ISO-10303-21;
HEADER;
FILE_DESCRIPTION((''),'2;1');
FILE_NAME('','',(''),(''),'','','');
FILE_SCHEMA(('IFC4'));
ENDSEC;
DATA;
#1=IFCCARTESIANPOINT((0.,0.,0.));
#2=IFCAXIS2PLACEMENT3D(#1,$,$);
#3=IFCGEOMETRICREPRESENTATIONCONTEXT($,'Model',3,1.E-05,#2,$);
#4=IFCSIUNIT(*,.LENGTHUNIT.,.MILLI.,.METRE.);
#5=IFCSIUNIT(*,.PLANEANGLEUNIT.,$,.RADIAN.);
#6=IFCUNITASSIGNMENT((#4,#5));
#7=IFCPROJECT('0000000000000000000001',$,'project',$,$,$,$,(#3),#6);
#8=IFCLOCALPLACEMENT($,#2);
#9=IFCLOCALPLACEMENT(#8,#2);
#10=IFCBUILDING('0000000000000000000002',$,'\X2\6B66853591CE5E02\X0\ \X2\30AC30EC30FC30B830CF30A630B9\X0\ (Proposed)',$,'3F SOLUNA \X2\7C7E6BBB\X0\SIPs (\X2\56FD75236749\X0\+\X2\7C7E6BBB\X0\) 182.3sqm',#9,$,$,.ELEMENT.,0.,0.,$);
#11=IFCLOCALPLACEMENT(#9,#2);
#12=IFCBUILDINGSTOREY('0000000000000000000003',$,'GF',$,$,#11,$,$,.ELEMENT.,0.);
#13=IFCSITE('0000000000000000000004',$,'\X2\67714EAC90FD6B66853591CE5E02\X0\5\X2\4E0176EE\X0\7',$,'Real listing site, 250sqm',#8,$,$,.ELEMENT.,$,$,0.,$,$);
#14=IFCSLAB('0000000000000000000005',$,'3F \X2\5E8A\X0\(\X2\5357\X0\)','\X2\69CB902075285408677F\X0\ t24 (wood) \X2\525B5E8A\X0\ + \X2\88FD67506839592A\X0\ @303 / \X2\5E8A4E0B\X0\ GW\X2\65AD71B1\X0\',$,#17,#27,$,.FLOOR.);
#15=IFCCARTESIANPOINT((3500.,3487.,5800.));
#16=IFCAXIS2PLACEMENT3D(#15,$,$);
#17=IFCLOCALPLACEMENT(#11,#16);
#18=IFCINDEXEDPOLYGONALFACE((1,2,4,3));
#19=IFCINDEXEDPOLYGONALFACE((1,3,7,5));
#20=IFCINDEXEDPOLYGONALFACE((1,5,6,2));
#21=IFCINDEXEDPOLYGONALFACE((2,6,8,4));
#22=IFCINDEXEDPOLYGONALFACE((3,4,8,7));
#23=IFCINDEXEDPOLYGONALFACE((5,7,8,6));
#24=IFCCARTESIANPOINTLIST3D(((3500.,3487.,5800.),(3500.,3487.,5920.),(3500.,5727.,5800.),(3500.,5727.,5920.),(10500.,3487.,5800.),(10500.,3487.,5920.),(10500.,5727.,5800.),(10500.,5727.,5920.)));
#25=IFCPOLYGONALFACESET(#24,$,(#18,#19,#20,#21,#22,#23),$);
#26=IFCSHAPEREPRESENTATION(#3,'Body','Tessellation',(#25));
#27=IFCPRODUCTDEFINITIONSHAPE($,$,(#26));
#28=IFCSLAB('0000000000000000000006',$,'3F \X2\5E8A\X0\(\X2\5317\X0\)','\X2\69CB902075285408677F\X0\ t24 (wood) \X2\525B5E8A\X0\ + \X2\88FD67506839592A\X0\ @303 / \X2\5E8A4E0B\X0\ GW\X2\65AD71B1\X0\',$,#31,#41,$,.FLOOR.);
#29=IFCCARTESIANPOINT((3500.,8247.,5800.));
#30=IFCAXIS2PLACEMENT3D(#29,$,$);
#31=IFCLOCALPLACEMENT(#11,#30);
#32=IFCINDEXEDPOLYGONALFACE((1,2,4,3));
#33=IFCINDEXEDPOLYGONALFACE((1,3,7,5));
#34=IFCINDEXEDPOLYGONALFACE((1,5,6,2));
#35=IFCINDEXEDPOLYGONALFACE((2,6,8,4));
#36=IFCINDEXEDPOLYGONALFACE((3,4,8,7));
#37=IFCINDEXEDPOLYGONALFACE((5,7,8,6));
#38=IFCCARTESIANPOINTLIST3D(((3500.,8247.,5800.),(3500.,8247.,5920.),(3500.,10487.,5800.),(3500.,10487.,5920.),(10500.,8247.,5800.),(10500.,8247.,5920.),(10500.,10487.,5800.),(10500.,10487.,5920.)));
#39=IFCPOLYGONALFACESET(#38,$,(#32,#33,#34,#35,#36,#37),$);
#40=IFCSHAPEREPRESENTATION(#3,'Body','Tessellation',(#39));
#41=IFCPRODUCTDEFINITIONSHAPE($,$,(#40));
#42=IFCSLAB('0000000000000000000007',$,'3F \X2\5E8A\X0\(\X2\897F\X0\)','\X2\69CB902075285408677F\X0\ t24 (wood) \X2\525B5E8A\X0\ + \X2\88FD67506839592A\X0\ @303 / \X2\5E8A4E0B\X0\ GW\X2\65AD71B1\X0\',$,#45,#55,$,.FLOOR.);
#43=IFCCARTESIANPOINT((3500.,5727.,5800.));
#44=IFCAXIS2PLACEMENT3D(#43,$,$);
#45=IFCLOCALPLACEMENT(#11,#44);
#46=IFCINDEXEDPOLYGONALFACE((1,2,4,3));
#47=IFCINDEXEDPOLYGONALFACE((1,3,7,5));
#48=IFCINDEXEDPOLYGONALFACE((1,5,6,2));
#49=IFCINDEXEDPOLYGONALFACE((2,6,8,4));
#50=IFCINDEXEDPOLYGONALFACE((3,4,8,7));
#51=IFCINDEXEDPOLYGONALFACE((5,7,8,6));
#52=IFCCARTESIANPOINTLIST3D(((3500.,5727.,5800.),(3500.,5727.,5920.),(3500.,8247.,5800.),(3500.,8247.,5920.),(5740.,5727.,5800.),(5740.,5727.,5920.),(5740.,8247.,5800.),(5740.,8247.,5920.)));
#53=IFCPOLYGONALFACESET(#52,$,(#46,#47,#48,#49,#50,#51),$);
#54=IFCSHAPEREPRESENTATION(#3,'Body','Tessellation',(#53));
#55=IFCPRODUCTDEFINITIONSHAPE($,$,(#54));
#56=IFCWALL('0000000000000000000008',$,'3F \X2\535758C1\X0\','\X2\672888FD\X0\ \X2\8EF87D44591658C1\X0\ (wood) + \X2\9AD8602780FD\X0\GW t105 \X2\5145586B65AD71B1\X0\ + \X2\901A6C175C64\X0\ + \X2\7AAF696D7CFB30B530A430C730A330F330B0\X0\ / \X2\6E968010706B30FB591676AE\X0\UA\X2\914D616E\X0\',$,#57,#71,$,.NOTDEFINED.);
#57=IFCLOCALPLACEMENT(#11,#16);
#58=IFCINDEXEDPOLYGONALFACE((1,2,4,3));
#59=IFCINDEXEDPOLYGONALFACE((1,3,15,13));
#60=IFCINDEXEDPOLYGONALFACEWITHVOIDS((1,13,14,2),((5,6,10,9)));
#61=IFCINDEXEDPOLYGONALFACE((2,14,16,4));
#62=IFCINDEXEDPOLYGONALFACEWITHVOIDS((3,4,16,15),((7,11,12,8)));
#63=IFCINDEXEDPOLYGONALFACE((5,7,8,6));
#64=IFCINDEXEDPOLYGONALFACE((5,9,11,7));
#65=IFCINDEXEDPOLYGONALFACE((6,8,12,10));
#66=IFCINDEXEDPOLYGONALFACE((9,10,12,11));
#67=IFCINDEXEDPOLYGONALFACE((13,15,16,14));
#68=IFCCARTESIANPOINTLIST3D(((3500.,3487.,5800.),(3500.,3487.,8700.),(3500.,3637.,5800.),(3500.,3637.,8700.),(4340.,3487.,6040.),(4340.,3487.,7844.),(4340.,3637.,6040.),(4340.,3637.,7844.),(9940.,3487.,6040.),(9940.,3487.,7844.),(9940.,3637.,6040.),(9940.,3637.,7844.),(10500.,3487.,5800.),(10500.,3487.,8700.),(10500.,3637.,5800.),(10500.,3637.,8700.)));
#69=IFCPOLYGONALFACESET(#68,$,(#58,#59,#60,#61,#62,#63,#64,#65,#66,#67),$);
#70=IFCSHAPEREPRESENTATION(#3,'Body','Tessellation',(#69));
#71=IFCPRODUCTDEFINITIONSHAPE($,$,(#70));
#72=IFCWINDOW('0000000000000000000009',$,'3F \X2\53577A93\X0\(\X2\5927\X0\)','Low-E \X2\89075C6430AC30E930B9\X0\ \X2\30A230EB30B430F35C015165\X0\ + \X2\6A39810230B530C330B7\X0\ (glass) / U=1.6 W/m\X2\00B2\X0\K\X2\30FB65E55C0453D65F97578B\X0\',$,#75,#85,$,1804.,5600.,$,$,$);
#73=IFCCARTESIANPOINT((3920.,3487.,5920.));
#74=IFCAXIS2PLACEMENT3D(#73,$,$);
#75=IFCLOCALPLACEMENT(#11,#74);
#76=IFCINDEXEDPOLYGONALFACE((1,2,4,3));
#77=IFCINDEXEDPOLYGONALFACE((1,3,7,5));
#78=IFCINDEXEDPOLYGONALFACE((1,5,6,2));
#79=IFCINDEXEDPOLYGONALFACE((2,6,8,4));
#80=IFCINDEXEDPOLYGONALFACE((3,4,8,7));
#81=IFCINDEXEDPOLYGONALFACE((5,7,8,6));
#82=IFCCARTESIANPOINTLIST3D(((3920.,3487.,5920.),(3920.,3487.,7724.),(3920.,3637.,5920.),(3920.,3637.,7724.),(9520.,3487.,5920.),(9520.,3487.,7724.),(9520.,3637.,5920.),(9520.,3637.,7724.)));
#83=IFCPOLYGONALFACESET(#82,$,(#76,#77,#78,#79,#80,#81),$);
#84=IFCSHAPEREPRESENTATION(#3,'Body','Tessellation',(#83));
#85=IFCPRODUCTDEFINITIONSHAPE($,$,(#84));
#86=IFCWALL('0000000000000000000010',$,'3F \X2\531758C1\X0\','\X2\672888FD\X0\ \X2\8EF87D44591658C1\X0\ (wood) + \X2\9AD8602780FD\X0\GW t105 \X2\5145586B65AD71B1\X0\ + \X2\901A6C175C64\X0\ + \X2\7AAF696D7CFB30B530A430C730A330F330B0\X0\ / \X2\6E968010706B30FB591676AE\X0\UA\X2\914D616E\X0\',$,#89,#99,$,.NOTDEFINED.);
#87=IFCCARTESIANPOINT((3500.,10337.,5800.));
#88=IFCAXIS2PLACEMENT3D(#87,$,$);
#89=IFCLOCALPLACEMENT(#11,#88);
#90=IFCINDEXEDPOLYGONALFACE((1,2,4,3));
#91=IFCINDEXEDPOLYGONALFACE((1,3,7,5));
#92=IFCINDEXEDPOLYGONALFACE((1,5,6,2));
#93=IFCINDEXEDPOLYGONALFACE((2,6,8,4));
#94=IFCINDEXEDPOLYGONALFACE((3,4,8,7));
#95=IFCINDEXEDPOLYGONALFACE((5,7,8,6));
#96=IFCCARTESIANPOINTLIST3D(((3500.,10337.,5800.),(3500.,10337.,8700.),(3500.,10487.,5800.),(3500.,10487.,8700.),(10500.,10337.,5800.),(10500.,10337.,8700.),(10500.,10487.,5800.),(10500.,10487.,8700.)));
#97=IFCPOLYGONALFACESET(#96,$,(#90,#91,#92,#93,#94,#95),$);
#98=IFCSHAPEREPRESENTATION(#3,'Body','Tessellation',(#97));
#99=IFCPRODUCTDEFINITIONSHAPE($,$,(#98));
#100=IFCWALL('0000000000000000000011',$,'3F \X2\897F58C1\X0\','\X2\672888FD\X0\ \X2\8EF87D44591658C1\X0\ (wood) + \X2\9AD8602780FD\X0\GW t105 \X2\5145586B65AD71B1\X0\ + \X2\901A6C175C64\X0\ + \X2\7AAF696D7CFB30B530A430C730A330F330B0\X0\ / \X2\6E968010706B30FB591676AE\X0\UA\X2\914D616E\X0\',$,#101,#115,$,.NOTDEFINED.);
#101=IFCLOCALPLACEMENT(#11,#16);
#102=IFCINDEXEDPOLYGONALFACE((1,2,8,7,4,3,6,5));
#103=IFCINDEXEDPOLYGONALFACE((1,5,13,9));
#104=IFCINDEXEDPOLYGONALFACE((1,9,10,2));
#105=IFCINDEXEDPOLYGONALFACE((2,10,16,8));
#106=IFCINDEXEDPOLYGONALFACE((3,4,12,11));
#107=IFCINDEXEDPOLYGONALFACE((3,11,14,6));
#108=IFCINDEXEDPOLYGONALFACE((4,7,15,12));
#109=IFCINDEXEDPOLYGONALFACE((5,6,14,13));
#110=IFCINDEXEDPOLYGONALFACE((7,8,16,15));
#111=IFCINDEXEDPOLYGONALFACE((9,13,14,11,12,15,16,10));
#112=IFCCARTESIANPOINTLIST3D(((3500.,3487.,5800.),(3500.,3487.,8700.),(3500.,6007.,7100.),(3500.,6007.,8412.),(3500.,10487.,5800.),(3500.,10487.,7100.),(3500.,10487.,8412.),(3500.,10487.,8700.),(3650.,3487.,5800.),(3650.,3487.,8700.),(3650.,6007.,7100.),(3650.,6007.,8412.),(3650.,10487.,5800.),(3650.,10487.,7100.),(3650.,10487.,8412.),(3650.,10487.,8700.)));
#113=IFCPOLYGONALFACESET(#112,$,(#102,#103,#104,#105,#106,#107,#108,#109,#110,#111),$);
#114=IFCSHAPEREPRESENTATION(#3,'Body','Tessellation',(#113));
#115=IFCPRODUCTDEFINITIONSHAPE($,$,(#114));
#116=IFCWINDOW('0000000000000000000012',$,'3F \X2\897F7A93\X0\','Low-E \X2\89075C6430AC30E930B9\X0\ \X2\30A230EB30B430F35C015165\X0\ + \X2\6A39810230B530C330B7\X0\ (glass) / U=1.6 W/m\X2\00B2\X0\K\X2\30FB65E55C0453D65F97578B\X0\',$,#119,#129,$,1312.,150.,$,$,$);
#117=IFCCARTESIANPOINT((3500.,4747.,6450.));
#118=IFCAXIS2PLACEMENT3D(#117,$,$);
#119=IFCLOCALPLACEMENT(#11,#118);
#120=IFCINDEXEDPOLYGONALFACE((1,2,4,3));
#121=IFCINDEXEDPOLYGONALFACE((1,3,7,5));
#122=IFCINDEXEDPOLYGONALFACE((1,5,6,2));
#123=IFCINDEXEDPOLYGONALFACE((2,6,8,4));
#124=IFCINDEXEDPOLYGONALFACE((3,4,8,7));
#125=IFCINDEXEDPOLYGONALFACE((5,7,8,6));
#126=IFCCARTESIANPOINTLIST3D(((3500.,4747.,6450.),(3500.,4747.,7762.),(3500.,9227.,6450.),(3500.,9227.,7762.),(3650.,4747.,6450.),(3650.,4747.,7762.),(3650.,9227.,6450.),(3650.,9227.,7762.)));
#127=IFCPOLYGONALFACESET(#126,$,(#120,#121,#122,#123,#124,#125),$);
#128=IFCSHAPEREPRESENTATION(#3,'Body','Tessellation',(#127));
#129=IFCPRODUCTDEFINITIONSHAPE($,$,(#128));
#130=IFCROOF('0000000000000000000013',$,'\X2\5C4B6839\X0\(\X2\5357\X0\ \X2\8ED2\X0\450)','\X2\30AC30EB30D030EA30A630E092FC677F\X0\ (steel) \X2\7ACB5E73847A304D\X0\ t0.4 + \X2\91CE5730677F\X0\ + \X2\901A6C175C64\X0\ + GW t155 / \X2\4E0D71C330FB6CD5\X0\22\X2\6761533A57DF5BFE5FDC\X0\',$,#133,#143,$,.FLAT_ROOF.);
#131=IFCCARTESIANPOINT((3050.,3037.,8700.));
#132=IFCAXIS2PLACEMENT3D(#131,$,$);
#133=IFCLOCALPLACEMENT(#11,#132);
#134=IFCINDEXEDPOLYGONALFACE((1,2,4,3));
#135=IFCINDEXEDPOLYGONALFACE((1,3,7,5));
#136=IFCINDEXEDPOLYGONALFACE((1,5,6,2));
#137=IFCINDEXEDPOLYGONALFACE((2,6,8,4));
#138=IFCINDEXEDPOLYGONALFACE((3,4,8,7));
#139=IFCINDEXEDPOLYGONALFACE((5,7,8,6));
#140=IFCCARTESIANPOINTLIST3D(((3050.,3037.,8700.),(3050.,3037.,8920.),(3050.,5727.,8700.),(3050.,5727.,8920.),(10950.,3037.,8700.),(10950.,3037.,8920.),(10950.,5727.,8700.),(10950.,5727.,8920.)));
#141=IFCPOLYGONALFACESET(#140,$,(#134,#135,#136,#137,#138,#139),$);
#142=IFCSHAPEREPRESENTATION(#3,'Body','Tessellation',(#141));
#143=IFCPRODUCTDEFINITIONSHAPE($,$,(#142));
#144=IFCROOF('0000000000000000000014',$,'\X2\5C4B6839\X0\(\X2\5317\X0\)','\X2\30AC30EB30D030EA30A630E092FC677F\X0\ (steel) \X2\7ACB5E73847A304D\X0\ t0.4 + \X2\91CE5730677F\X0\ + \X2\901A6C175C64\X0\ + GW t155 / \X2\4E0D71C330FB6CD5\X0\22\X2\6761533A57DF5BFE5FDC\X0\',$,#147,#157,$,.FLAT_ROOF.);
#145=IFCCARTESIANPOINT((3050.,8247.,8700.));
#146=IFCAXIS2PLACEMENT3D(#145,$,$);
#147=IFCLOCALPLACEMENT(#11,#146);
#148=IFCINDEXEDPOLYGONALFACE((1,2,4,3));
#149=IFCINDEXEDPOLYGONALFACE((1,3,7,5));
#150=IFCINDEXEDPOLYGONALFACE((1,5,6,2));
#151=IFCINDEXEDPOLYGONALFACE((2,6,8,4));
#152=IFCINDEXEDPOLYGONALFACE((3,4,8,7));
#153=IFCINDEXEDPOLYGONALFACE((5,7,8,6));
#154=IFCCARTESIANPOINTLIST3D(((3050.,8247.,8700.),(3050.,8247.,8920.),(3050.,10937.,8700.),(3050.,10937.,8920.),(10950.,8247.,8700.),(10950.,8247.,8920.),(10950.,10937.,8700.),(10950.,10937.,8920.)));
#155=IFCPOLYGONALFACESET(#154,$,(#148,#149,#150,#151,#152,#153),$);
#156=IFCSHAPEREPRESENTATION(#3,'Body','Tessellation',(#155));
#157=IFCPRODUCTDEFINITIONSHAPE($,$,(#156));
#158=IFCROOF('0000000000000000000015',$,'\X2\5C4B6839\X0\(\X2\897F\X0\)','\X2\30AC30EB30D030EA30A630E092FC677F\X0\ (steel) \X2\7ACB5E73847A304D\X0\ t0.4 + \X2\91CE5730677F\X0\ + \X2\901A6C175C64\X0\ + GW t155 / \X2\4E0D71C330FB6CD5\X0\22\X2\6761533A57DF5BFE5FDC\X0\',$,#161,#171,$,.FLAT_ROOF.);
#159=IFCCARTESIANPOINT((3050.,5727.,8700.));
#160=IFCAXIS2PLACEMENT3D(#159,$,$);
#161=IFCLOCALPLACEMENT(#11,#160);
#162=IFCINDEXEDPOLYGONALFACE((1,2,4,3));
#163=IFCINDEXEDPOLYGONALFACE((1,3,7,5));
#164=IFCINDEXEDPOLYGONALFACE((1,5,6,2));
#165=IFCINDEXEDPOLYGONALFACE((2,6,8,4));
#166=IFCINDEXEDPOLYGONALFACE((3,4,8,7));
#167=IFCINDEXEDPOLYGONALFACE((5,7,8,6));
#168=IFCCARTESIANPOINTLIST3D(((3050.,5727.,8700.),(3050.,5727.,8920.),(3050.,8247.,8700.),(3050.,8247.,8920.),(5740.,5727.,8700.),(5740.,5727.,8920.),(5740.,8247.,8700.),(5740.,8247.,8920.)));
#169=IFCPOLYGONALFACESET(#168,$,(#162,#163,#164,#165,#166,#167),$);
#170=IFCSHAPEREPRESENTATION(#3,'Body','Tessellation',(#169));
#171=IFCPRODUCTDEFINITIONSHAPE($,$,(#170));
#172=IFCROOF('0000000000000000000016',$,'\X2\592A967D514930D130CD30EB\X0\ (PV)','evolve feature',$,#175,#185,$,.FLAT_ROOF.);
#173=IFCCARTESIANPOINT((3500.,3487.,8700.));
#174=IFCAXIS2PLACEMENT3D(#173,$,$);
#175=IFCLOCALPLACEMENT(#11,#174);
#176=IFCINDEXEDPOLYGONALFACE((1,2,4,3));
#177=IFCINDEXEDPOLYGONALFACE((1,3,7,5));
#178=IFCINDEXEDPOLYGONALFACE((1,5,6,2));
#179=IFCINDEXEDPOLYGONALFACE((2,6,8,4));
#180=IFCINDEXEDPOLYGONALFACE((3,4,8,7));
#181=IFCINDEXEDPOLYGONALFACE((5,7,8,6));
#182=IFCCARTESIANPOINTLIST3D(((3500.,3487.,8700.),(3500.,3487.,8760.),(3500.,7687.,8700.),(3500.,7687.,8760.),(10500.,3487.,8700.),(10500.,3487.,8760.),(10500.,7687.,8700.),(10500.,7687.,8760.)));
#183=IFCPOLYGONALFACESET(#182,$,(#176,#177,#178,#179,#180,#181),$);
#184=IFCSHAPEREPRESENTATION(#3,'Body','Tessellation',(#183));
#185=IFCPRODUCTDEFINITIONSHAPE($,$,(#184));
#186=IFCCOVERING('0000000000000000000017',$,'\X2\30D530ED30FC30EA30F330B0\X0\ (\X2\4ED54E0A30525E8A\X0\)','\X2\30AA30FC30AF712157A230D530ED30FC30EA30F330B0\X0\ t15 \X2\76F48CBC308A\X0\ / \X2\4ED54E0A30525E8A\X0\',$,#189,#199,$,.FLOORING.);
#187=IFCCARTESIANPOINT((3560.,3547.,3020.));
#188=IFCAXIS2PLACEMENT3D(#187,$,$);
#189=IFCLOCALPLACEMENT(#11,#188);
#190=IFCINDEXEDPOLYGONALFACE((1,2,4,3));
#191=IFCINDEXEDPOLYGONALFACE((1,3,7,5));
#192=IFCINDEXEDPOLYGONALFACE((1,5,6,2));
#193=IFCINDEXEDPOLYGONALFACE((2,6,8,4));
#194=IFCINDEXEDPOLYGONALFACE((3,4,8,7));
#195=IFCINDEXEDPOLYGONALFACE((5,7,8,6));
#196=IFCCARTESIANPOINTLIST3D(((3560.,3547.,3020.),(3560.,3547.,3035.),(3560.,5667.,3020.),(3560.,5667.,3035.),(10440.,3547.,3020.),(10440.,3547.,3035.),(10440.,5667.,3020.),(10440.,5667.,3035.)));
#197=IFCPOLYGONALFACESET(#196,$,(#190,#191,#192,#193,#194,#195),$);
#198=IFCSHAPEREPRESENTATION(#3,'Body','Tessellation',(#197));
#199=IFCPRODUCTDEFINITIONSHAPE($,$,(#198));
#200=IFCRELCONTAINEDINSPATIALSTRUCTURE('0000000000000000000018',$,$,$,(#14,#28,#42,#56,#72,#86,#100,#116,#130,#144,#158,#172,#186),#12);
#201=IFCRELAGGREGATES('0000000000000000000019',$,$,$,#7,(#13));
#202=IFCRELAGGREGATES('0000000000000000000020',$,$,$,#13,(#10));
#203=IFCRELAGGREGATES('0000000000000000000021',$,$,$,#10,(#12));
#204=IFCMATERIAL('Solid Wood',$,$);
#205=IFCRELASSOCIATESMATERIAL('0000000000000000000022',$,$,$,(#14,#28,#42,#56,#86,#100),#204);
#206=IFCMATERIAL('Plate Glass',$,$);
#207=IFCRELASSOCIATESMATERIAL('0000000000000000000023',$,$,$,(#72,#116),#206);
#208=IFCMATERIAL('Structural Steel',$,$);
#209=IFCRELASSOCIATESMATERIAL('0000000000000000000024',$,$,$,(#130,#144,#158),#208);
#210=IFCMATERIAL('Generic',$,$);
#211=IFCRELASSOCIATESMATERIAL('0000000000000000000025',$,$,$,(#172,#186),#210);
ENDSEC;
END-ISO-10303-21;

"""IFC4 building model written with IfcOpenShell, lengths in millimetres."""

from ifc_helpers import new_model, si_unit, frame, frame_2d, origin, place, context, project, spatial, rectangle, extrude, material, element, fill, save


model = new_model("IFC4")

# Units and contexts
model_context = context("Model", 3, precision=1e-05, world=origin())
ifc_project = project(units=[si_unit("LENGTHUNIT", "METRE", prefix="MILLI"), si_unit("PLANEANGLEUNIT", "RADIAN")], contexts=[model_context])

# Site, building, storey
site_placement = place(None, origin())
site = spatial("IfcSite", under=ifc_project, at=site_placement, Name="東京都武蔵野市5丁目7", ObjectType="Real listing site, 250sqm", CompositionType="ELEMENT", RefElevation=0.0)
building_placement = place(site_placement, origin())
building = spatial("IfcBuilding", under=site, at=building_placement, Name="武蔵野市 ガレージハウス (Proposed)", ObjectType="3F SOLUNA 籾殻SIPs (国産杉+籾殻) 182.3sqm", CompositionType="ELEMENT", ElevationOfRefHeight=0.0, ElevationOfTerrain=0.0)
storey_placement = place(building_placement, origin())
storey = spatial("IfcBuildingStorey", under=building, at=storey_placement, Name="GF", CompositionType="ELEMENT", Elevation=0.0)

# Slabs
ifc_material_1 = material(Name="Solid Wood")
slab_1_placement = place(storey_placement, frame((3500.0, 3487.0, 5800.0)))
element("IfcSlab", 1, at=slab_1_placement, inside=storey, material=ifc_material_1, Name="3F 床(南)", Description="構造用合板 t24 (wood) 剛床 + 製材根太 @303 / 床下 GW断熱", PredefinedType="FLOOR", context=model_context, shape_type="SweptSolid", body=[
    extrude(rectangle(XDim=7000.0, YDim=2240.0, at=frame_2d((3500.0, 1120.0))), frame((3500.0, 3487.0, 5800.0)), (0.0, 0.0, 1.0), 120.0),
])
slab_2_placement = place(storey_placement, frame((3500.0, 8247.0, 5800.0)))
element("IfcSlab", 2, at=slab_2_placement, inside=storey, material=ifc_material_1, Name="3F 床(北)", Description="構造用合板 t24 (wood) 剛床 + 製材根太 @303 / 床下 GW断熱", PredefinedType="FLOOR", context=model_context, shape_type="SweptSolid", body=[
    extrude(rectangle(XDim=7000.0, YDim=2240.0, at=frame_2d((3500.0, 1120.0))), frame((3500.0, 8247.0, 5800.0)), (0.0, 0.0, 1.0), 120.0),
])
slab_3_placement = place(storey_placement, frame((3500.0, 5727.0, 5800.0)))
element("IfcSlab", 3, at=slab_3_placement, inside=storey, material=ifc_material_1, Name="3F 床(西)", Description="構造用合板 t24 (wood) 剛床 + 製材根太 @303 / 床下 GW断熱", PredefinedType="FLOOR", context=model_context, shape_type="SweptSolid", body=[
    extrude(rectangle(XDim=2240.0, YDim=2520.0, at=frame_2d((1120.0, 1260.0))), frame((3500.0, 5727.0, 5800.0)), (0.0, 0.0, 1.0), 120.0),
])

# Wall, opening, window
wall_1_placement = place(storey_placement, frame((3500.0, 3487.0, 5800.0)))
wall_1 = element("IfcWall", 4, at=wall_1_placement, inside=storey, material=ifc_material_1, Name="3F 南壁", Description="木製 軸組外壁 (wood) + 高性能GW t105 充填断熱 + 通気層 + 窯業系サイディング / 準耐火・外皮UA配慮", PredefinedType="NOTDEFINED", context=model_context, shape_type="SweptSolid", body=[
    extrude(rectangle(XDim=7000.0, YDim=150.0, at=frame_2d((3500.0, 75.0))), frame((3500.0, 3487.0, 5800.0)), (0.0, 0.0, 1.0), 2900.0),
])
opening_1_placement = place(storey_placement, frame((3920.0, 3487.0, 5920.0)))
opening_1 = element("IfcOpeningElement", 5, at=opening_1_placement, cuts=wall_1, PredefinedType="NOTDEFINED", context=model_context, shape_type="SweptSolid", body=[
    extrude(rectangle(XDim=5600.0, YDim=150.0, at=frame_2d((2800.0, 75.0))), frame((3920.0, 3487.0, 5920.0)), (0.0, 0.0, 1.0), 1804.0),
])
ifc_material_2 = material(Name="Plate Glass")
window_1_placement = place(storey_placement, frame((3920.0, 3487.0, 5920.0)))
window_1 = element("IfcWindow", 6, at=window_1_placement, inside=storey, material=ifc_material_2, Name="3F 南窓(大)", Description="Low-E 複層ガラス アルゴン封入 + 樹脂サッシ (glass) / U=1.6 W/m²K・日射取得型", OverallHeight=1804.0, OverallWidth=5600.0, context=model_context, shape_type="SweptSolid", body=[
    extrude(rectangle(XDim=5600.0, YDim=150.0, at=frame_2d((2800.0, 75.0))), frame((3920.0, 3487.0, 5920.0)), (0.0, 0.0, 1.0), 1804.0),
])
fill(opening_1, window_1)

# Wall
wall_2_placement = place(storey_placement, frame((3500.0, 10337.0, 5800.0)))
element("IfcWall", 7, at=wall_2_placement, inside=storey, material=ifc_material_1, Name="3F 北壁", Description="木製 軸組外壁 (wood) + 高性能GW t105 充填断熱 + 通気層 + 窯業系サイディング / 準耐火・外皮UA配慮", PredefinedType="NOTDEFINED", context=model_context, shape_type="SweptSolid", body=[
    extrude(rectangle(XDim=7000.0, YDim=150.0, at=frame_2d((3500.0, 75.0))), frame((3500.0, 10337.0, 5800.0)), (0.0, 0.0, 1.0), 2900.0),
])

# Wall, opening, window
wall_3_placement = place(storey_placement, frame((3500.0, 3487.0, 5800.0)))
wall_3 = element("IfcWall", 8, at=wall_3_placement, inside=storey, material=ifc_material_1, Name="3F 西壁", Description="木製 軸組外壁 (wood) + 高性能GW t105 充填断熱 + 通気層 + 窯業系サイディング / 準耐火・外皮UA配慮", PredefinedType="NOTDEFINED", context=model_context, shape_type="SweptSolid", body=[
    extrude(rectangle(XDim=150.0, YDim=7000.0, at=frame_2d((75.0, 3500.0))), frame((3500.0, 3487.0, 5800.0)), (0.0, 0.0, 1.0), 2900.0),
])
opening_2_placement = place(storey_placement, frame((3500.0, 4747.0, 6450.0)))
opening_2 = element("IfcOpeningElement", 9, at=opening_2_placement, cuts=wall_3, PredefinedType="NOTDEFINED", context=model_context, shape_type="SweptSolid", body=[
    extrude(rectangle(XDim=150.0, YDim=4480.0, at=frame_2d((75.0, 2240.0))), frame((3500.0, 4747.0, 6450.0)), (0.0, 0.0, 1.0), 1312.0),
])
window_2_placement = place(storey_placement, frame((3500.0, 4747.0, 6450.0)))
window_2 = element("IfcWindow", 10, at=window_2_placement, inside=storey, material=ifc_material_2, Name="3F 西窓", Description="Low-E 複層ガラス アルゴン封入 + 樹脂サッシ (glass) / U=1.6 W/m²K・日射取得型", OverallHeight=1312.0, OverallWidth=150.0, context=model_context, shape_type="SweptSolid", body=[
    extrude(rectangle(XDim=150.0, YDim=4480.0, at=frame_2d((75.0, 2240.0))), frame((3500.0, 4747.0, 6450.0)), (0.0, 0.0, 1.0), 1312.0),
])
fill(opening_2, window_2)

# Roofs
ifc_material_3 = material(Name="Structural Steel")
roof_1_placement = place(storey_placement, frame((3050.0, 3037.0, 8700.0)))
element("IfcRoof", 11, at=roof_1_placement, inside=storey, material=ifc_material_3, Name="屋根(南 軒450)", Description="ガルバリウム鋼板 (steel) 立平葺き t0.4 + 野地板 + 通気層 + GW t155 / 不燃・法22条区域対応", PredefinedType="FLAT_ROOF", context=model_context, shape_type="SweptSolid", body=[
    extrude(rectangle(XDim=7900.0, YDim=2690.0, at=frame_2d((3950.0, 1345.0))), frame((3050.0, 3037.0, 8700.0)), (0.0, 0.0, 1.0), 220.0),
])
roof_2_placement = place(storey_placement, frame((3050.0, 8247.0, 8700.0)))
element("IfcRoof", 12, at=roof_2_placement, inside=storey, material=ifc_material_3, Name="屋根(北)", Description="ガルバリウム鋼板 (steel) 立平葺き t0.4 + 野地板 + 通気層 + GW t155 / 不燃・法22条区域対応", PredefinedType="FLAT_ROOF", context=model_context, shape_type="SweptSolid", body=[
    extrude(rectangle(XDim=7900.0, YDim=2690.0, at=frame_2d((3950.0, 1345.0))), frame((3050.0, 8247.0, 8700.0)), (0.0, 0.0, 1.0), 220.0),
])
roof_3_placement = place(storey_placement, frame((3050.0, 5727.0, 8700.0)))
element("IfcRoof", 13, at=roof_3_placement, inside=storey, material=ifc_material_3, Name="屋根(西)", Description="ガルバリウム鋼板 (steel) 立平葺き t0.4 + 野地板 + 通気層 + GW t155 / 不燃・法22条区域対応", PredefinedType="FLAT_ROOF", context=model_context, shape_type="SweptSolid", body=[
    extrude(rectangle(XDim=2690.0, YDim=2520.0, at=frame_2d((1345.0, 1260.0))), frame((3050.0, 5727.0, 8700.0)), (0.0, 0.0, 1.0), 220.0),
])
ifc_material_4 = material(Name="Generic")
roof_4_placement = place(storey_placement, frame((3500.0, 3487.0, 8700.0)))
element("IfcRoof", 14, at=roof_4_placement, inside=storey, material=ifc_material_4, Name="太陽光パネル (PV)", Description="evolve feature", PredefinedType="FLAT_ROOF", context=model_context, shape_type="SweptSolid", body=[
    extrude(rectangle(XDim=7000.0, YDim=4200.0, at=frame_2d((3500.0, 2100.0))), frame((3500.0, 3487.0, 8700.0)), (0.0, 0.0, 1.0), 60.0),
])

# Covering
covering_1_placement = place(storey_placement, frame((3560.0, 3547.0, 3020.0)))
element("IfcCovering", 15, at=covering_1_placement, inside=storey, material=ifc_material_4, Name="フローリング (仕上げ床)", Description="オーク無垢フローリング t15 直貼り / 仕上げ床", PredefinedType="FLOORING", context=model_context, shape_type="SweptSolid", body=[
    extrude(rectangle(XDim=6880.0, YDim=2120.0, at=frame_2d((3440.0, 1060.0))), frame((3560.0, 3547.0, 3020.0)), (0.0, 0.0, 1.0), 15.0),
])

save(model, "model.ifc")
